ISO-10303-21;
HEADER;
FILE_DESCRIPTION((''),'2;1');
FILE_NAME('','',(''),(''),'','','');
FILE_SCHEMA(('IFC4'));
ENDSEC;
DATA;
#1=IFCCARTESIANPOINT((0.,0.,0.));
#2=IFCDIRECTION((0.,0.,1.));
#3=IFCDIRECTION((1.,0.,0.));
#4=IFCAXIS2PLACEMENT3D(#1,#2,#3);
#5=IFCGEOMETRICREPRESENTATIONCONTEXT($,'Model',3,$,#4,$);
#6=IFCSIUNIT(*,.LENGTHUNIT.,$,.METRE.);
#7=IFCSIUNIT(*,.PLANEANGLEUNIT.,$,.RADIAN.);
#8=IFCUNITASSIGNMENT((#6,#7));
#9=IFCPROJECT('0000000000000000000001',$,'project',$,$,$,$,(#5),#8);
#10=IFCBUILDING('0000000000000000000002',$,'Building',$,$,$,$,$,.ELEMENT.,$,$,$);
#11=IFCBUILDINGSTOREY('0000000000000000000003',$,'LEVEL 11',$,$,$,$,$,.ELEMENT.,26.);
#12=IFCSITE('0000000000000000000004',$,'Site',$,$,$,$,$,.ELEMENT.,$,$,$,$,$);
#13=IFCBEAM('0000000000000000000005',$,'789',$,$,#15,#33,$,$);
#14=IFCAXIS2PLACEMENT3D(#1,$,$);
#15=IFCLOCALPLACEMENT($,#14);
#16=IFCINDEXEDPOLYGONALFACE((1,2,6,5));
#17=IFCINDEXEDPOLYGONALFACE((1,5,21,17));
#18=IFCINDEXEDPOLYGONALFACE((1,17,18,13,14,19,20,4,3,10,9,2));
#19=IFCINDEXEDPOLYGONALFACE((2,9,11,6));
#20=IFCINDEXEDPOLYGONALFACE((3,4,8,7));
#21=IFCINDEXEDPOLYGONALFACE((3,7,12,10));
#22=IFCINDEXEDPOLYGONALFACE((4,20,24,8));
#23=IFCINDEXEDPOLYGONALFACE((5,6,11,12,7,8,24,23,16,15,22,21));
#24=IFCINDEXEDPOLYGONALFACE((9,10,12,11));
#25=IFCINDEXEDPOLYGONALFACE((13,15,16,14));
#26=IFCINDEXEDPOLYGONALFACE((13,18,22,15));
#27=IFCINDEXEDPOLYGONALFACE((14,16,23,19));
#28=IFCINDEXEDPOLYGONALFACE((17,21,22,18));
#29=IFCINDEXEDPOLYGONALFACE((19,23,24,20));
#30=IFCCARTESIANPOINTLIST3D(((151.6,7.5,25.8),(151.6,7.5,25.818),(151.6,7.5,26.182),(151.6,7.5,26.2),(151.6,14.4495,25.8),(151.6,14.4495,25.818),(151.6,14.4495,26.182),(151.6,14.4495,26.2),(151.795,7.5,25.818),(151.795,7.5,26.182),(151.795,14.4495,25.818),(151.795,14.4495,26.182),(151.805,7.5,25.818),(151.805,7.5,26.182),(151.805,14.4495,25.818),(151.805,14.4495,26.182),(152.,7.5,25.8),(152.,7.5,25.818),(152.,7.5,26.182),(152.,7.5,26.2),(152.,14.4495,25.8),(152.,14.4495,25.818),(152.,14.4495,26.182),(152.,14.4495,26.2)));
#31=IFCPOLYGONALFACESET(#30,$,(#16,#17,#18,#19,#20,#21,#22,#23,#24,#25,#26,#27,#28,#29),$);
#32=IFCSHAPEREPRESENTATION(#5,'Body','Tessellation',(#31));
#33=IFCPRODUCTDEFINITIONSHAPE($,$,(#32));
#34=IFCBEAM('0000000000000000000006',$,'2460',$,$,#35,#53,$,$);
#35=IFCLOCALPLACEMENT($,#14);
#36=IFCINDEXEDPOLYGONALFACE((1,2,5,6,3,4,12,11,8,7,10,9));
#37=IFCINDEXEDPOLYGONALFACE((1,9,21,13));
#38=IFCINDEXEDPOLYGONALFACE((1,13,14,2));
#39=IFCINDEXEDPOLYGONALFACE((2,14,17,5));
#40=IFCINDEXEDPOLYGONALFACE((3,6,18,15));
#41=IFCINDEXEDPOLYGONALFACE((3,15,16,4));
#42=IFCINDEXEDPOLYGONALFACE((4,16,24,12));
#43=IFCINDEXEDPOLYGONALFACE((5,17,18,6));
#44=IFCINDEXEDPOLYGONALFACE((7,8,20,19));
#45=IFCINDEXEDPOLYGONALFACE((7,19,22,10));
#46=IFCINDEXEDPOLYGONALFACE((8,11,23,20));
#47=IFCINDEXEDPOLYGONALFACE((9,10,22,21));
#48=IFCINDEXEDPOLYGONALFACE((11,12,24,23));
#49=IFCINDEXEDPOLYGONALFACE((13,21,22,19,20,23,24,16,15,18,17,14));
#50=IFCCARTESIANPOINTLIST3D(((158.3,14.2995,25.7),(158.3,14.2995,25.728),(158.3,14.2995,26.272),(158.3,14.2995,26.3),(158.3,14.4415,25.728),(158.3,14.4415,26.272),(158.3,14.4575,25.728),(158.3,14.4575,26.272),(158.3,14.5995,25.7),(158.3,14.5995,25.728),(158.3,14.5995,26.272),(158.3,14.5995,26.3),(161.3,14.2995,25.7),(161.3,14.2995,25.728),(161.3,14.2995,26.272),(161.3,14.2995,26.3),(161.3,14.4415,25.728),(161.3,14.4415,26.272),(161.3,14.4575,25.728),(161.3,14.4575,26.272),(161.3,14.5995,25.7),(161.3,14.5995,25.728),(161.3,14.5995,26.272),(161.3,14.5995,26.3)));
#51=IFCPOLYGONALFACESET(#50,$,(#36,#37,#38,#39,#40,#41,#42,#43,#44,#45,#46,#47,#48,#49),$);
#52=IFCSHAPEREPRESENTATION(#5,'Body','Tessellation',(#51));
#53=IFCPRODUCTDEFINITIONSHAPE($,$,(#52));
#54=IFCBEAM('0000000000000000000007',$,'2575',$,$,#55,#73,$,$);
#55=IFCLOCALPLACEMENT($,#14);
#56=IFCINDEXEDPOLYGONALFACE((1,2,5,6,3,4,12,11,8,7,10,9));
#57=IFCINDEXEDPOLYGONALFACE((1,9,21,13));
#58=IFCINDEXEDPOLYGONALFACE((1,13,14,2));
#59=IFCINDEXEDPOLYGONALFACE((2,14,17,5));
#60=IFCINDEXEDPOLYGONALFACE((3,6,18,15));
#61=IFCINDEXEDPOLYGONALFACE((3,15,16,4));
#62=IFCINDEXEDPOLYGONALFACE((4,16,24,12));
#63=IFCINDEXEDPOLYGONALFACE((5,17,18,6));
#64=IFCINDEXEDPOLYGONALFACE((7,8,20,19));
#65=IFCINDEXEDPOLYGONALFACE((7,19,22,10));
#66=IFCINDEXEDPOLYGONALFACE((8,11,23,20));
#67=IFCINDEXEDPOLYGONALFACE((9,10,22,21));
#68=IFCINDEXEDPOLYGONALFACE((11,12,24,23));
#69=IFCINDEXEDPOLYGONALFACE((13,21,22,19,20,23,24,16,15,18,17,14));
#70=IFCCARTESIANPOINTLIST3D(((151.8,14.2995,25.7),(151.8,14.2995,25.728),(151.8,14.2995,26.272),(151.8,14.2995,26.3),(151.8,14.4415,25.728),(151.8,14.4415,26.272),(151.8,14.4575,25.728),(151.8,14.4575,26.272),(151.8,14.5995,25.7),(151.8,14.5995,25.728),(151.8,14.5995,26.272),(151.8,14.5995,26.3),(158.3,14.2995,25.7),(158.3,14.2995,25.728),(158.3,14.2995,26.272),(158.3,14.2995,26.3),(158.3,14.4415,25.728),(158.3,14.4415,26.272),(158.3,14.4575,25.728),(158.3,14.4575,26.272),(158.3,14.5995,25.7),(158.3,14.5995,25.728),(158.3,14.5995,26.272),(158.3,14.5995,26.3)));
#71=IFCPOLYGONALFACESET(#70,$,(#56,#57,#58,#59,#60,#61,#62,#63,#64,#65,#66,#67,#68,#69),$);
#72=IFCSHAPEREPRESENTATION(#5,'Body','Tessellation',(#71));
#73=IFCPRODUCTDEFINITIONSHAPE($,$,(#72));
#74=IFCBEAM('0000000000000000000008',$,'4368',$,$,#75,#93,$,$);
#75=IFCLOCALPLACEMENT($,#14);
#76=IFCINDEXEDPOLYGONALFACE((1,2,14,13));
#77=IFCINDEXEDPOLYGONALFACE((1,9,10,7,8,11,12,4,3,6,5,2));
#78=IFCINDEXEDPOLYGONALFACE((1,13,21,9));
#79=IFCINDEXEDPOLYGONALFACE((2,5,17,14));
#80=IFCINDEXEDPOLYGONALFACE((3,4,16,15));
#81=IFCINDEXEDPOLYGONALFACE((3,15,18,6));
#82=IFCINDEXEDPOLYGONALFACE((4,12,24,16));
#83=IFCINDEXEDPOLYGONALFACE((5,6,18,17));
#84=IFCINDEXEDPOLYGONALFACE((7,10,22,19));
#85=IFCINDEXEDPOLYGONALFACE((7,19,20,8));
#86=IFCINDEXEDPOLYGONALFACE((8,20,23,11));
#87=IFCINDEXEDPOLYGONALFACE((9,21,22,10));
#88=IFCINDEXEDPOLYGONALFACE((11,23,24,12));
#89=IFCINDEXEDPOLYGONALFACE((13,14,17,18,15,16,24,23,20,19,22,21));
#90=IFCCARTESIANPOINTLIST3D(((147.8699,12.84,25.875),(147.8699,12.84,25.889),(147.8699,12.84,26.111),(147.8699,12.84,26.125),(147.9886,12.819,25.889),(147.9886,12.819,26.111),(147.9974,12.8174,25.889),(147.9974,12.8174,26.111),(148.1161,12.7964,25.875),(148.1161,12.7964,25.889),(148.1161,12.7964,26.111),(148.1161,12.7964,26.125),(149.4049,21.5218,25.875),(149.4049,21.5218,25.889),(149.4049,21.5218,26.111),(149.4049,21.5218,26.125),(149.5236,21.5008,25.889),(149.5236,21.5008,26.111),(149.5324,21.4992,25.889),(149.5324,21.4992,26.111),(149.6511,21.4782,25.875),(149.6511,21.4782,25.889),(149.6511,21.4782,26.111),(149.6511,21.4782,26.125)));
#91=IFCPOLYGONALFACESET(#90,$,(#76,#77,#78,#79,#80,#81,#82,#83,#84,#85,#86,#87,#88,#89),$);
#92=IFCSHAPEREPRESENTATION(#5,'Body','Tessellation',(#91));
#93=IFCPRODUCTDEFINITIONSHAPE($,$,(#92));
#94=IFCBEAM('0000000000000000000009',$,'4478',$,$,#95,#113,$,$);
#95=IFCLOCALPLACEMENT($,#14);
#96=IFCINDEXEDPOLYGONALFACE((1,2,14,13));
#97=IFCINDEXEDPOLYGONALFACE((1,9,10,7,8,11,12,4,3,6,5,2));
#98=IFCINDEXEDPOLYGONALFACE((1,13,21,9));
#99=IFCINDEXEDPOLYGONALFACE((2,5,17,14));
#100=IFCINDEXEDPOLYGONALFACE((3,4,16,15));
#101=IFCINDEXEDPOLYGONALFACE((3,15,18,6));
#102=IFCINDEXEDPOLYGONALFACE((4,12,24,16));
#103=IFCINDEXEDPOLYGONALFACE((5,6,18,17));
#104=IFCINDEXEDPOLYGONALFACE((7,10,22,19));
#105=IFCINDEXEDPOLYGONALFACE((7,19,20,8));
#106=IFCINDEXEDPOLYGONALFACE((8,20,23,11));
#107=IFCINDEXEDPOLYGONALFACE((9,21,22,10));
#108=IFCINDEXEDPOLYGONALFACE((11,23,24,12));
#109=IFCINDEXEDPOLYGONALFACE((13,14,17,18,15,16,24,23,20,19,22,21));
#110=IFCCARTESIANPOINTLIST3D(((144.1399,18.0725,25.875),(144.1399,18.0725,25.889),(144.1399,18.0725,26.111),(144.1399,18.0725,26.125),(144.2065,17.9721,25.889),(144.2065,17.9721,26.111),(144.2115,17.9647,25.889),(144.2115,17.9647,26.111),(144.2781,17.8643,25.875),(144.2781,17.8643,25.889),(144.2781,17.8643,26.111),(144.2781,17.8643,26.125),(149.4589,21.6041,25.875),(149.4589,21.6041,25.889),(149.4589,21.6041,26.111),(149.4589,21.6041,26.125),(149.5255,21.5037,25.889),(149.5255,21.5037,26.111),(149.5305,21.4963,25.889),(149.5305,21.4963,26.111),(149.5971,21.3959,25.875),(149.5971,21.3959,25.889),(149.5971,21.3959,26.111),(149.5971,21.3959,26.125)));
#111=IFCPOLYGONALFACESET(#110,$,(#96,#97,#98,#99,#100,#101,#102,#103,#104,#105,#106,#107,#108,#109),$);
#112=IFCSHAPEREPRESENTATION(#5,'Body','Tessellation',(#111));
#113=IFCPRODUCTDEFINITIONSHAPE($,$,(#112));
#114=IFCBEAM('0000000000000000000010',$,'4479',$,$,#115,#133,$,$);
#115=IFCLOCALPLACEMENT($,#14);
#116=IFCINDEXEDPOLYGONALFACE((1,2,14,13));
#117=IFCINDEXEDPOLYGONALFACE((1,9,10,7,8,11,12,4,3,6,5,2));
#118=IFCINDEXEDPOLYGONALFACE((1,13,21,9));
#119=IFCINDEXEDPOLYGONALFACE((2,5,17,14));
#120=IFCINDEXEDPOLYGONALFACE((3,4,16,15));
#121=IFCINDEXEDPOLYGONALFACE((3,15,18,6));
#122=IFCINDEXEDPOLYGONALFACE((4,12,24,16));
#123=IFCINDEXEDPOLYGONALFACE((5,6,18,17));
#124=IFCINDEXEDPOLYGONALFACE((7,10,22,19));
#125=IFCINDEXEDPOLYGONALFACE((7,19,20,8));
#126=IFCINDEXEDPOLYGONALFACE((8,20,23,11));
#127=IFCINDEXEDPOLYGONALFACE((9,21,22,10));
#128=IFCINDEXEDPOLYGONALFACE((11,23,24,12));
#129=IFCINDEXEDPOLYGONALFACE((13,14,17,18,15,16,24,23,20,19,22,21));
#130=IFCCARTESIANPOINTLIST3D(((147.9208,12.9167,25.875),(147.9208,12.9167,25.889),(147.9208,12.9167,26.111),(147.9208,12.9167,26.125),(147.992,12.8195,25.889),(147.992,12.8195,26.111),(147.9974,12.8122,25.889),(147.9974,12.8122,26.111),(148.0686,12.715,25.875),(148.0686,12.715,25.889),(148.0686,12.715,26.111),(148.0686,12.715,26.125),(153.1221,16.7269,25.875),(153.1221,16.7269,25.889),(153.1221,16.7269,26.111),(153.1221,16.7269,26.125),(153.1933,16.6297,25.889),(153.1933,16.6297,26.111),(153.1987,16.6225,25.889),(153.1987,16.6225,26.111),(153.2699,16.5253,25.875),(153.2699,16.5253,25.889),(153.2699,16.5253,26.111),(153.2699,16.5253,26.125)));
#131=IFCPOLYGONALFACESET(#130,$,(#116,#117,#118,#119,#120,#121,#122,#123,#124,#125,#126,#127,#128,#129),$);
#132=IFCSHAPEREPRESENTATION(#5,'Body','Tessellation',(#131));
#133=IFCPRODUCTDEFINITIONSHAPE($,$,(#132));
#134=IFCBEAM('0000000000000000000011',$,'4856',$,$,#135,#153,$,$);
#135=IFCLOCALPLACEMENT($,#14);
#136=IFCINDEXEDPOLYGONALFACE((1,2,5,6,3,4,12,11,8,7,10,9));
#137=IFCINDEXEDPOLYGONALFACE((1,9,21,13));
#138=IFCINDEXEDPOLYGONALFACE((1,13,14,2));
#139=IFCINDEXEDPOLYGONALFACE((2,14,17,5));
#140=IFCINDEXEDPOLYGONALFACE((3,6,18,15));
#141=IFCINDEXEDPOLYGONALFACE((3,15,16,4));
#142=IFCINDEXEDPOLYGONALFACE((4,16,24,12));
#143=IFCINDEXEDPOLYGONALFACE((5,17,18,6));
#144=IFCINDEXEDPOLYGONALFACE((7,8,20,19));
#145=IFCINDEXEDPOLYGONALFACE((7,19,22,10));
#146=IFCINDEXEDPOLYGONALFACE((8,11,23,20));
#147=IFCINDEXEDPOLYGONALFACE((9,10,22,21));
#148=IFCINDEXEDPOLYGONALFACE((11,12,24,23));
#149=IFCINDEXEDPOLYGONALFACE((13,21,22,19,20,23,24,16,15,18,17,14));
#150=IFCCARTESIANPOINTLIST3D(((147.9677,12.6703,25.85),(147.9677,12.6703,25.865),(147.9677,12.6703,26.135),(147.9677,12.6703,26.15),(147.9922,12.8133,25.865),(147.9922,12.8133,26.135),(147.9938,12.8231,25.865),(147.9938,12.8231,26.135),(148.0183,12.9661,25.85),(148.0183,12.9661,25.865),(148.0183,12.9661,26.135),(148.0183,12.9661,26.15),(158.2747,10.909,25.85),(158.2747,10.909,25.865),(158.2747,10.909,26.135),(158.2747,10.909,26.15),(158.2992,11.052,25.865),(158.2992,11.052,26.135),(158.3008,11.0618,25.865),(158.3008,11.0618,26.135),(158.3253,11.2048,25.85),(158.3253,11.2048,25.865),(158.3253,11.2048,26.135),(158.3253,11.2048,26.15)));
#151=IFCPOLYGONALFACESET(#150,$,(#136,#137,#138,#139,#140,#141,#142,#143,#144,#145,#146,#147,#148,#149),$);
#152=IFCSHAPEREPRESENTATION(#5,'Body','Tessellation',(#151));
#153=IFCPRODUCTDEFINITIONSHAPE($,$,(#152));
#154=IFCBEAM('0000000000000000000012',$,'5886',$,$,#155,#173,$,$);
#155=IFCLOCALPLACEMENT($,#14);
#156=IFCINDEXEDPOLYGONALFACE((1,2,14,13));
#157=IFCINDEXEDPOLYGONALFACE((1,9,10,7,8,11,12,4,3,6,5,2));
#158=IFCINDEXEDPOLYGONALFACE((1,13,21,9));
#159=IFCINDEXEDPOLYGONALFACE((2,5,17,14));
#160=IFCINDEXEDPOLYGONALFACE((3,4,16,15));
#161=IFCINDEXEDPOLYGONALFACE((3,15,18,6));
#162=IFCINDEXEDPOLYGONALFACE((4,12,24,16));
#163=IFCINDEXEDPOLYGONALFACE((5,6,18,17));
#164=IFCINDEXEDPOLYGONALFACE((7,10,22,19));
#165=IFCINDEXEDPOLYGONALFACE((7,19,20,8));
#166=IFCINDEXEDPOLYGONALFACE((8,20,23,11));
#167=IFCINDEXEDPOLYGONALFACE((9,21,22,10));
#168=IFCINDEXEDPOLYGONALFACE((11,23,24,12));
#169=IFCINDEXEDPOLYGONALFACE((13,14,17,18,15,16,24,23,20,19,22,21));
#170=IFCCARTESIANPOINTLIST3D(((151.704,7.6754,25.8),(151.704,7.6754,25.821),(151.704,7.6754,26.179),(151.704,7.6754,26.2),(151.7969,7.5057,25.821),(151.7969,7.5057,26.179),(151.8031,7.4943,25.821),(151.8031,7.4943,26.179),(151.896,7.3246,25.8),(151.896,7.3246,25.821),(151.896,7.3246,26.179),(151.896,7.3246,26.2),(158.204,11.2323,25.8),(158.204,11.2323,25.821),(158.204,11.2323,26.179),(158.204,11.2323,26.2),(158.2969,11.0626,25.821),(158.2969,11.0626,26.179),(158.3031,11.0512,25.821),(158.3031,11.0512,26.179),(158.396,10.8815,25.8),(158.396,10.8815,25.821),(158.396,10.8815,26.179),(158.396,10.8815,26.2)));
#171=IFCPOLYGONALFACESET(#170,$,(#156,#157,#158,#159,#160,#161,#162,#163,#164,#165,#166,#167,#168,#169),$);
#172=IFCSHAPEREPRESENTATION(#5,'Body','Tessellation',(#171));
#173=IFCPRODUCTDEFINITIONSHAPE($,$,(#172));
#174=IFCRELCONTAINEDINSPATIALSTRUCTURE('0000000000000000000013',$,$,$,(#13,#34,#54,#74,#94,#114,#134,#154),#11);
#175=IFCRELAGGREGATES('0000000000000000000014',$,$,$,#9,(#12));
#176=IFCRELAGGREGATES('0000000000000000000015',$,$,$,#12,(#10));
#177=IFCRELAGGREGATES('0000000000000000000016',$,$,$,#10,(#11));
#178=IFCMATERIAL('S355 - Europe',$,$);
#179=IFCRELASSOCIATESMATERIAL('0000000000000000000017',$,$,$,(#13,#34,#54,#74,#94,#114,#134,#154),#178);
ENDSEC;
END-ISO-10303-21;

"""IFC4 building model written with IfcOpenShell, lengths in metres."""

from ifc_helpers import new_model, si_unit, frame, origin_with_axes, origin_2d_with_axis, place, context, project, spatial, i_section, extrude, material, material_profile, profile_set, profile_usage, element, save


model = new_model("IFC4")

# Units and contexts
model_context = context("Model", 3, world=origin_with_axes())
ifc_project = project(units=[si_unit("LENGTHUNIT", "METRE"), si_unit("PLANEANGLEUNIT", "RADIAN")], contexts=[model_context])

# Site, building, storey
site = spatial("IfcSite", under=ifc_project, Name="Site", CompositionType="ELEMENT")
building = spatial("IfcBuilding", under=site, Name="Building", CompositionType="ELEMENT")
storey = spatial("IfcBuildingStorey", under=building, Name="LEVEL 11", CompositionType="ELEMENT", Elevation=26.0)

# Shared definitions
ifc_material = material(Name="S355 - Europe")

# Beams
ifc_material_profile_1 = material_profile(ifc_material, i_section(OverallWidth=0.4, OverallDepth=0.4, WebThickness=0.01, FlangeThickness=0.018, at=origin_2d_with_axis()))
ifc_profile_set_1 = profile_set([ifc_material_profile_1])
ifc_profile_usage_1 = profile_usage(ifc_profile_set_1, cardinal=10)
beam_1_placement = place(None, frame((151.8, 14.4495, 26.0), z_axis=(0.0, -1.0, 0.0), x_axis=(1.0, 0.0, 0.0)))
element("IfcBeam", 1, at=beam_1_placement, inside=storey, material=ifc_profile_usage_1, Name="789", context=model_context, shape_type="SweptSolid", body=[
    extrude(i_section(OverallWidth=0.4, OverallDepth=0.4, WebThickness=0.01, FlangeThickness=0.018, at=origin_2d_with_axis()), origin_with_axes(), (0.0, 0.0, 1.0), 6.9495),
])
ifc_material_profile_2 = material_profile(ifc_material, i_section(OverallWidth=0.3, OverallDepth=0.6, WebThickness=0.016, FlangeThickness=0.028, at=origin_2d_with_axis()))
ifc_profile_set_2 = profile_set([ifc_material_profile_2])
ifc_profile_usage_2 = profile_usage(ifc_profile_set_2, cardinal=10)
beam_2_placement = place(None, frame((158.3, 14.4495, 26.0), z_axis=(1.0, 0.0, 0.0), x_axis=(0.0, 1.0, 0.0)))
element("IfcBeam", 2, at=beam_2_placement, inside=storey, material=ifc_profile_usage_2, Name="2460", context=model_context, shape_type="SweptSolid", body=[
    extrude(i_section(OverallWidth=0.3, OverallDepth=0.6, WebThickness=0.016, FlangeThickness=0.028, at=origin_2d_with_axis()), origin_with_axes(), (0.0, 0.0, 1.0), 3.0),
])
ifc_material_profile_3 = material_profile(ifc_material, i_section(OverallWidth=0.3, OverallDepth=0.6, WebThickness=0.016, FlangeThickness=0.028, at=origin_2d_with_axis()))
ifc_profile_set_3 = profile_set([ifc_material_profile_3])
ifc_profile_usage_3 = profile_usage(ifc_profile_set_3, cardinal=10)
beam_3_placement = place(None, frame((151.8, 14.4495, 26.0), z_axis=(1.0, 0.0, 0.0), x_axis=(0.0, 1.0, 0.0)))
element("IfcBeam", 3, at=beam_3_placement, inside=storey, material=ifc_profile_usage_3, Name="2575", context=model_context, shape_type="SweptSolid", body=[
    extrude(i_section(OverallWidth=0.3, OverallDepth=0.6, WebThickness=0.016, FlangeThickness=0.028, at=origin_2d_with_axis()), origin_with_axes(), (0.0, 0.0, 1.0), 6.5),
])
ifc_material_profile_4 = material_profile(ifc_material, i_section(OverallWidth=0.25, OverallDepth=0.25, WebThickness=0.009, FlangeThickness=0.014, at=origin_2d_with_axis()))
ifc_profile_set_4 = profile_set([ifc_material_profile_4])
ifc_profile_usage_4 = profile_usage(ifc_profile_set_4, cardinal=10)
beam_4_placement = place(None, frame((147.993, 12.8182, 26.0), z_axis=(0.174106, 0.984727, 0.0), x_axis=(-0.984727, 0.174106, 0.0)))
element("IfcBeam", 4, at=beam_4_placement, inside=storey, material=ifc_profile_usage_4, Name="4368", context=model_context, shape_type="SweptSolid", body=[
    extrude(i_section(OverallWidth=0.25, OverallDepth=0.25, WebThickness=0.009, FlangeThickness=0.014, at=origin_2d_with_axis()), origin_with_axes(), (0.0, 0.0, 1.0), 8.8165),
])
ifc_material_profile_5 = material_profile(ifc_material, i_section(OverallWidth=0.25, OverallDepth=0.25, WebThickness=0.009, FlangeThickness=0.014, at=origin_2d_with_axis()))
ifc_profile_set_5 = profile_set([ifc_material_profile_5])
ifc_profile_usage_5 = profile_usage(ifc_profile_set_5, cardinal=10)
beam_5_placement = place(None, frame((149.528, 21.5, 26.0), z_axis=(-0.83309, -0.553138, 0.0), x_axis=(0.553138, -0.83309, 0.0)))
element("IfcBeam", 5, at=beam_5_placement, inside=storey, material=ifc_profile_usage_5, Name="4478", context=model_context, shape_type="SweptSolid", body=[
    extrude(i_section(OverallWidth=0.25, OverallDepth=0.25, WebThickness=0.009, FlangeThickness=0.014, at=origin_2d_with_axis()), origin_with_axes(), (0.0, 0.0, 1.0), 6.3847),
])
ifc_material_profile_6 = material_profile(ifc_material, i_section(OverallWidth=0.25, OverallDepth=0.25, WebThickness=0.009, FlangeThickness=0.014, at=origin_2d_with_axis()))
ifc_profile_set_6 = profile_set([ifc_material_profile_6])
ifc_profile_usage_6 = profile_usage(ifc_profile_set_6, cardinal=10)
beam_6_placement = place(None, frame((153.196, 16.6261, 26.0), z_axis=(-0.806706, -0.590953, 0.0), x_axis=(0.590953, -0.806706, 0.0)))
element("IfcBeam", 6, at=beam_6_placement, inside=storey, material=ifc_profile_usage_6, Name="4479", context=model_context, shape_type="SweptSolid", body=[
    extrude(i_section(OverallWidth=0.25, OverallDepth=0.25, WebThickness=0.009, FlangeThickness=0.014, at=origin_2d_with_axis()), origin_with_axes(), (0.0, 0.0, 1.0), 6.4476),
])
ifc_material_profile_7 = material_profile(ifc_material, i_section(OverallWidth=0.3, OverallDepth=0.3, WebThickness=0.01, FlangeThickness=0.015, at=origin_2d_with_axis()))
ifc_profile_set_7 = profile_set([ifc_material_profile_7])
ifc_profile_usage_7 = profile_usage(ifc_profile_set_7, cardinal=10)
beam_7_placement = place(None, frame((147.993, 12.8182, 26.0), z_axis=(0.985712, -0.168442, 0.0), x_axis=(0.168442, 0.985712, 0.0)))
element("IfcBeam", 7, at=beam_7_placement, inside=storey, material=ifc_profile_usage_7, Name="4856", context=model_context, shape_type="SweptSolid", body=[
    extrude(i_section(OverallWidth=0.3, OverallDepth=0.3, WebThickness=0.01, FlangeThickness=0.015, at=origin_2d_with_axis()), origin_with_axes(), (0.0, 0.0, 1.0), 10.4564),
])
ifc_material_profile_8 = material_profile(ifc_material, i_section(OverallWidth=0.4, OverallDepth=0.4, WebThickness=0.013, FlangeThickness=0.021, at=origin_2d_with_axis()))
ifc_profile_set_8 = profile_set([ifc_material_profile_8])
ifc_profile_usage_8 = profile_usage(ifc_profile_set_8, cardinal=10)
beam_8_placement = place(None, frame((158.3, 11.0569, 26.0), z_axis=(-0.877245, -0.480042, 0.0), x_axis=(0.480042, -0.877245, 0.0)))
element("IfcBeam", 8, at=beam_8_placement, inside=storey, material=ifc_profile_usage_8, Name="5886", context=model_context, shape_type="SweptSolid", body=[
    extrude(i_section(OverallWidth=0.4, OverallDepth=0.4, WebThickness=0.013, FlangeThickness=0.021, at=origin_2d_with_axis()), origin_with_axes(), (0.0, 0.0, 1.0), 7.4096),
])

save(model, "model.ifc")
